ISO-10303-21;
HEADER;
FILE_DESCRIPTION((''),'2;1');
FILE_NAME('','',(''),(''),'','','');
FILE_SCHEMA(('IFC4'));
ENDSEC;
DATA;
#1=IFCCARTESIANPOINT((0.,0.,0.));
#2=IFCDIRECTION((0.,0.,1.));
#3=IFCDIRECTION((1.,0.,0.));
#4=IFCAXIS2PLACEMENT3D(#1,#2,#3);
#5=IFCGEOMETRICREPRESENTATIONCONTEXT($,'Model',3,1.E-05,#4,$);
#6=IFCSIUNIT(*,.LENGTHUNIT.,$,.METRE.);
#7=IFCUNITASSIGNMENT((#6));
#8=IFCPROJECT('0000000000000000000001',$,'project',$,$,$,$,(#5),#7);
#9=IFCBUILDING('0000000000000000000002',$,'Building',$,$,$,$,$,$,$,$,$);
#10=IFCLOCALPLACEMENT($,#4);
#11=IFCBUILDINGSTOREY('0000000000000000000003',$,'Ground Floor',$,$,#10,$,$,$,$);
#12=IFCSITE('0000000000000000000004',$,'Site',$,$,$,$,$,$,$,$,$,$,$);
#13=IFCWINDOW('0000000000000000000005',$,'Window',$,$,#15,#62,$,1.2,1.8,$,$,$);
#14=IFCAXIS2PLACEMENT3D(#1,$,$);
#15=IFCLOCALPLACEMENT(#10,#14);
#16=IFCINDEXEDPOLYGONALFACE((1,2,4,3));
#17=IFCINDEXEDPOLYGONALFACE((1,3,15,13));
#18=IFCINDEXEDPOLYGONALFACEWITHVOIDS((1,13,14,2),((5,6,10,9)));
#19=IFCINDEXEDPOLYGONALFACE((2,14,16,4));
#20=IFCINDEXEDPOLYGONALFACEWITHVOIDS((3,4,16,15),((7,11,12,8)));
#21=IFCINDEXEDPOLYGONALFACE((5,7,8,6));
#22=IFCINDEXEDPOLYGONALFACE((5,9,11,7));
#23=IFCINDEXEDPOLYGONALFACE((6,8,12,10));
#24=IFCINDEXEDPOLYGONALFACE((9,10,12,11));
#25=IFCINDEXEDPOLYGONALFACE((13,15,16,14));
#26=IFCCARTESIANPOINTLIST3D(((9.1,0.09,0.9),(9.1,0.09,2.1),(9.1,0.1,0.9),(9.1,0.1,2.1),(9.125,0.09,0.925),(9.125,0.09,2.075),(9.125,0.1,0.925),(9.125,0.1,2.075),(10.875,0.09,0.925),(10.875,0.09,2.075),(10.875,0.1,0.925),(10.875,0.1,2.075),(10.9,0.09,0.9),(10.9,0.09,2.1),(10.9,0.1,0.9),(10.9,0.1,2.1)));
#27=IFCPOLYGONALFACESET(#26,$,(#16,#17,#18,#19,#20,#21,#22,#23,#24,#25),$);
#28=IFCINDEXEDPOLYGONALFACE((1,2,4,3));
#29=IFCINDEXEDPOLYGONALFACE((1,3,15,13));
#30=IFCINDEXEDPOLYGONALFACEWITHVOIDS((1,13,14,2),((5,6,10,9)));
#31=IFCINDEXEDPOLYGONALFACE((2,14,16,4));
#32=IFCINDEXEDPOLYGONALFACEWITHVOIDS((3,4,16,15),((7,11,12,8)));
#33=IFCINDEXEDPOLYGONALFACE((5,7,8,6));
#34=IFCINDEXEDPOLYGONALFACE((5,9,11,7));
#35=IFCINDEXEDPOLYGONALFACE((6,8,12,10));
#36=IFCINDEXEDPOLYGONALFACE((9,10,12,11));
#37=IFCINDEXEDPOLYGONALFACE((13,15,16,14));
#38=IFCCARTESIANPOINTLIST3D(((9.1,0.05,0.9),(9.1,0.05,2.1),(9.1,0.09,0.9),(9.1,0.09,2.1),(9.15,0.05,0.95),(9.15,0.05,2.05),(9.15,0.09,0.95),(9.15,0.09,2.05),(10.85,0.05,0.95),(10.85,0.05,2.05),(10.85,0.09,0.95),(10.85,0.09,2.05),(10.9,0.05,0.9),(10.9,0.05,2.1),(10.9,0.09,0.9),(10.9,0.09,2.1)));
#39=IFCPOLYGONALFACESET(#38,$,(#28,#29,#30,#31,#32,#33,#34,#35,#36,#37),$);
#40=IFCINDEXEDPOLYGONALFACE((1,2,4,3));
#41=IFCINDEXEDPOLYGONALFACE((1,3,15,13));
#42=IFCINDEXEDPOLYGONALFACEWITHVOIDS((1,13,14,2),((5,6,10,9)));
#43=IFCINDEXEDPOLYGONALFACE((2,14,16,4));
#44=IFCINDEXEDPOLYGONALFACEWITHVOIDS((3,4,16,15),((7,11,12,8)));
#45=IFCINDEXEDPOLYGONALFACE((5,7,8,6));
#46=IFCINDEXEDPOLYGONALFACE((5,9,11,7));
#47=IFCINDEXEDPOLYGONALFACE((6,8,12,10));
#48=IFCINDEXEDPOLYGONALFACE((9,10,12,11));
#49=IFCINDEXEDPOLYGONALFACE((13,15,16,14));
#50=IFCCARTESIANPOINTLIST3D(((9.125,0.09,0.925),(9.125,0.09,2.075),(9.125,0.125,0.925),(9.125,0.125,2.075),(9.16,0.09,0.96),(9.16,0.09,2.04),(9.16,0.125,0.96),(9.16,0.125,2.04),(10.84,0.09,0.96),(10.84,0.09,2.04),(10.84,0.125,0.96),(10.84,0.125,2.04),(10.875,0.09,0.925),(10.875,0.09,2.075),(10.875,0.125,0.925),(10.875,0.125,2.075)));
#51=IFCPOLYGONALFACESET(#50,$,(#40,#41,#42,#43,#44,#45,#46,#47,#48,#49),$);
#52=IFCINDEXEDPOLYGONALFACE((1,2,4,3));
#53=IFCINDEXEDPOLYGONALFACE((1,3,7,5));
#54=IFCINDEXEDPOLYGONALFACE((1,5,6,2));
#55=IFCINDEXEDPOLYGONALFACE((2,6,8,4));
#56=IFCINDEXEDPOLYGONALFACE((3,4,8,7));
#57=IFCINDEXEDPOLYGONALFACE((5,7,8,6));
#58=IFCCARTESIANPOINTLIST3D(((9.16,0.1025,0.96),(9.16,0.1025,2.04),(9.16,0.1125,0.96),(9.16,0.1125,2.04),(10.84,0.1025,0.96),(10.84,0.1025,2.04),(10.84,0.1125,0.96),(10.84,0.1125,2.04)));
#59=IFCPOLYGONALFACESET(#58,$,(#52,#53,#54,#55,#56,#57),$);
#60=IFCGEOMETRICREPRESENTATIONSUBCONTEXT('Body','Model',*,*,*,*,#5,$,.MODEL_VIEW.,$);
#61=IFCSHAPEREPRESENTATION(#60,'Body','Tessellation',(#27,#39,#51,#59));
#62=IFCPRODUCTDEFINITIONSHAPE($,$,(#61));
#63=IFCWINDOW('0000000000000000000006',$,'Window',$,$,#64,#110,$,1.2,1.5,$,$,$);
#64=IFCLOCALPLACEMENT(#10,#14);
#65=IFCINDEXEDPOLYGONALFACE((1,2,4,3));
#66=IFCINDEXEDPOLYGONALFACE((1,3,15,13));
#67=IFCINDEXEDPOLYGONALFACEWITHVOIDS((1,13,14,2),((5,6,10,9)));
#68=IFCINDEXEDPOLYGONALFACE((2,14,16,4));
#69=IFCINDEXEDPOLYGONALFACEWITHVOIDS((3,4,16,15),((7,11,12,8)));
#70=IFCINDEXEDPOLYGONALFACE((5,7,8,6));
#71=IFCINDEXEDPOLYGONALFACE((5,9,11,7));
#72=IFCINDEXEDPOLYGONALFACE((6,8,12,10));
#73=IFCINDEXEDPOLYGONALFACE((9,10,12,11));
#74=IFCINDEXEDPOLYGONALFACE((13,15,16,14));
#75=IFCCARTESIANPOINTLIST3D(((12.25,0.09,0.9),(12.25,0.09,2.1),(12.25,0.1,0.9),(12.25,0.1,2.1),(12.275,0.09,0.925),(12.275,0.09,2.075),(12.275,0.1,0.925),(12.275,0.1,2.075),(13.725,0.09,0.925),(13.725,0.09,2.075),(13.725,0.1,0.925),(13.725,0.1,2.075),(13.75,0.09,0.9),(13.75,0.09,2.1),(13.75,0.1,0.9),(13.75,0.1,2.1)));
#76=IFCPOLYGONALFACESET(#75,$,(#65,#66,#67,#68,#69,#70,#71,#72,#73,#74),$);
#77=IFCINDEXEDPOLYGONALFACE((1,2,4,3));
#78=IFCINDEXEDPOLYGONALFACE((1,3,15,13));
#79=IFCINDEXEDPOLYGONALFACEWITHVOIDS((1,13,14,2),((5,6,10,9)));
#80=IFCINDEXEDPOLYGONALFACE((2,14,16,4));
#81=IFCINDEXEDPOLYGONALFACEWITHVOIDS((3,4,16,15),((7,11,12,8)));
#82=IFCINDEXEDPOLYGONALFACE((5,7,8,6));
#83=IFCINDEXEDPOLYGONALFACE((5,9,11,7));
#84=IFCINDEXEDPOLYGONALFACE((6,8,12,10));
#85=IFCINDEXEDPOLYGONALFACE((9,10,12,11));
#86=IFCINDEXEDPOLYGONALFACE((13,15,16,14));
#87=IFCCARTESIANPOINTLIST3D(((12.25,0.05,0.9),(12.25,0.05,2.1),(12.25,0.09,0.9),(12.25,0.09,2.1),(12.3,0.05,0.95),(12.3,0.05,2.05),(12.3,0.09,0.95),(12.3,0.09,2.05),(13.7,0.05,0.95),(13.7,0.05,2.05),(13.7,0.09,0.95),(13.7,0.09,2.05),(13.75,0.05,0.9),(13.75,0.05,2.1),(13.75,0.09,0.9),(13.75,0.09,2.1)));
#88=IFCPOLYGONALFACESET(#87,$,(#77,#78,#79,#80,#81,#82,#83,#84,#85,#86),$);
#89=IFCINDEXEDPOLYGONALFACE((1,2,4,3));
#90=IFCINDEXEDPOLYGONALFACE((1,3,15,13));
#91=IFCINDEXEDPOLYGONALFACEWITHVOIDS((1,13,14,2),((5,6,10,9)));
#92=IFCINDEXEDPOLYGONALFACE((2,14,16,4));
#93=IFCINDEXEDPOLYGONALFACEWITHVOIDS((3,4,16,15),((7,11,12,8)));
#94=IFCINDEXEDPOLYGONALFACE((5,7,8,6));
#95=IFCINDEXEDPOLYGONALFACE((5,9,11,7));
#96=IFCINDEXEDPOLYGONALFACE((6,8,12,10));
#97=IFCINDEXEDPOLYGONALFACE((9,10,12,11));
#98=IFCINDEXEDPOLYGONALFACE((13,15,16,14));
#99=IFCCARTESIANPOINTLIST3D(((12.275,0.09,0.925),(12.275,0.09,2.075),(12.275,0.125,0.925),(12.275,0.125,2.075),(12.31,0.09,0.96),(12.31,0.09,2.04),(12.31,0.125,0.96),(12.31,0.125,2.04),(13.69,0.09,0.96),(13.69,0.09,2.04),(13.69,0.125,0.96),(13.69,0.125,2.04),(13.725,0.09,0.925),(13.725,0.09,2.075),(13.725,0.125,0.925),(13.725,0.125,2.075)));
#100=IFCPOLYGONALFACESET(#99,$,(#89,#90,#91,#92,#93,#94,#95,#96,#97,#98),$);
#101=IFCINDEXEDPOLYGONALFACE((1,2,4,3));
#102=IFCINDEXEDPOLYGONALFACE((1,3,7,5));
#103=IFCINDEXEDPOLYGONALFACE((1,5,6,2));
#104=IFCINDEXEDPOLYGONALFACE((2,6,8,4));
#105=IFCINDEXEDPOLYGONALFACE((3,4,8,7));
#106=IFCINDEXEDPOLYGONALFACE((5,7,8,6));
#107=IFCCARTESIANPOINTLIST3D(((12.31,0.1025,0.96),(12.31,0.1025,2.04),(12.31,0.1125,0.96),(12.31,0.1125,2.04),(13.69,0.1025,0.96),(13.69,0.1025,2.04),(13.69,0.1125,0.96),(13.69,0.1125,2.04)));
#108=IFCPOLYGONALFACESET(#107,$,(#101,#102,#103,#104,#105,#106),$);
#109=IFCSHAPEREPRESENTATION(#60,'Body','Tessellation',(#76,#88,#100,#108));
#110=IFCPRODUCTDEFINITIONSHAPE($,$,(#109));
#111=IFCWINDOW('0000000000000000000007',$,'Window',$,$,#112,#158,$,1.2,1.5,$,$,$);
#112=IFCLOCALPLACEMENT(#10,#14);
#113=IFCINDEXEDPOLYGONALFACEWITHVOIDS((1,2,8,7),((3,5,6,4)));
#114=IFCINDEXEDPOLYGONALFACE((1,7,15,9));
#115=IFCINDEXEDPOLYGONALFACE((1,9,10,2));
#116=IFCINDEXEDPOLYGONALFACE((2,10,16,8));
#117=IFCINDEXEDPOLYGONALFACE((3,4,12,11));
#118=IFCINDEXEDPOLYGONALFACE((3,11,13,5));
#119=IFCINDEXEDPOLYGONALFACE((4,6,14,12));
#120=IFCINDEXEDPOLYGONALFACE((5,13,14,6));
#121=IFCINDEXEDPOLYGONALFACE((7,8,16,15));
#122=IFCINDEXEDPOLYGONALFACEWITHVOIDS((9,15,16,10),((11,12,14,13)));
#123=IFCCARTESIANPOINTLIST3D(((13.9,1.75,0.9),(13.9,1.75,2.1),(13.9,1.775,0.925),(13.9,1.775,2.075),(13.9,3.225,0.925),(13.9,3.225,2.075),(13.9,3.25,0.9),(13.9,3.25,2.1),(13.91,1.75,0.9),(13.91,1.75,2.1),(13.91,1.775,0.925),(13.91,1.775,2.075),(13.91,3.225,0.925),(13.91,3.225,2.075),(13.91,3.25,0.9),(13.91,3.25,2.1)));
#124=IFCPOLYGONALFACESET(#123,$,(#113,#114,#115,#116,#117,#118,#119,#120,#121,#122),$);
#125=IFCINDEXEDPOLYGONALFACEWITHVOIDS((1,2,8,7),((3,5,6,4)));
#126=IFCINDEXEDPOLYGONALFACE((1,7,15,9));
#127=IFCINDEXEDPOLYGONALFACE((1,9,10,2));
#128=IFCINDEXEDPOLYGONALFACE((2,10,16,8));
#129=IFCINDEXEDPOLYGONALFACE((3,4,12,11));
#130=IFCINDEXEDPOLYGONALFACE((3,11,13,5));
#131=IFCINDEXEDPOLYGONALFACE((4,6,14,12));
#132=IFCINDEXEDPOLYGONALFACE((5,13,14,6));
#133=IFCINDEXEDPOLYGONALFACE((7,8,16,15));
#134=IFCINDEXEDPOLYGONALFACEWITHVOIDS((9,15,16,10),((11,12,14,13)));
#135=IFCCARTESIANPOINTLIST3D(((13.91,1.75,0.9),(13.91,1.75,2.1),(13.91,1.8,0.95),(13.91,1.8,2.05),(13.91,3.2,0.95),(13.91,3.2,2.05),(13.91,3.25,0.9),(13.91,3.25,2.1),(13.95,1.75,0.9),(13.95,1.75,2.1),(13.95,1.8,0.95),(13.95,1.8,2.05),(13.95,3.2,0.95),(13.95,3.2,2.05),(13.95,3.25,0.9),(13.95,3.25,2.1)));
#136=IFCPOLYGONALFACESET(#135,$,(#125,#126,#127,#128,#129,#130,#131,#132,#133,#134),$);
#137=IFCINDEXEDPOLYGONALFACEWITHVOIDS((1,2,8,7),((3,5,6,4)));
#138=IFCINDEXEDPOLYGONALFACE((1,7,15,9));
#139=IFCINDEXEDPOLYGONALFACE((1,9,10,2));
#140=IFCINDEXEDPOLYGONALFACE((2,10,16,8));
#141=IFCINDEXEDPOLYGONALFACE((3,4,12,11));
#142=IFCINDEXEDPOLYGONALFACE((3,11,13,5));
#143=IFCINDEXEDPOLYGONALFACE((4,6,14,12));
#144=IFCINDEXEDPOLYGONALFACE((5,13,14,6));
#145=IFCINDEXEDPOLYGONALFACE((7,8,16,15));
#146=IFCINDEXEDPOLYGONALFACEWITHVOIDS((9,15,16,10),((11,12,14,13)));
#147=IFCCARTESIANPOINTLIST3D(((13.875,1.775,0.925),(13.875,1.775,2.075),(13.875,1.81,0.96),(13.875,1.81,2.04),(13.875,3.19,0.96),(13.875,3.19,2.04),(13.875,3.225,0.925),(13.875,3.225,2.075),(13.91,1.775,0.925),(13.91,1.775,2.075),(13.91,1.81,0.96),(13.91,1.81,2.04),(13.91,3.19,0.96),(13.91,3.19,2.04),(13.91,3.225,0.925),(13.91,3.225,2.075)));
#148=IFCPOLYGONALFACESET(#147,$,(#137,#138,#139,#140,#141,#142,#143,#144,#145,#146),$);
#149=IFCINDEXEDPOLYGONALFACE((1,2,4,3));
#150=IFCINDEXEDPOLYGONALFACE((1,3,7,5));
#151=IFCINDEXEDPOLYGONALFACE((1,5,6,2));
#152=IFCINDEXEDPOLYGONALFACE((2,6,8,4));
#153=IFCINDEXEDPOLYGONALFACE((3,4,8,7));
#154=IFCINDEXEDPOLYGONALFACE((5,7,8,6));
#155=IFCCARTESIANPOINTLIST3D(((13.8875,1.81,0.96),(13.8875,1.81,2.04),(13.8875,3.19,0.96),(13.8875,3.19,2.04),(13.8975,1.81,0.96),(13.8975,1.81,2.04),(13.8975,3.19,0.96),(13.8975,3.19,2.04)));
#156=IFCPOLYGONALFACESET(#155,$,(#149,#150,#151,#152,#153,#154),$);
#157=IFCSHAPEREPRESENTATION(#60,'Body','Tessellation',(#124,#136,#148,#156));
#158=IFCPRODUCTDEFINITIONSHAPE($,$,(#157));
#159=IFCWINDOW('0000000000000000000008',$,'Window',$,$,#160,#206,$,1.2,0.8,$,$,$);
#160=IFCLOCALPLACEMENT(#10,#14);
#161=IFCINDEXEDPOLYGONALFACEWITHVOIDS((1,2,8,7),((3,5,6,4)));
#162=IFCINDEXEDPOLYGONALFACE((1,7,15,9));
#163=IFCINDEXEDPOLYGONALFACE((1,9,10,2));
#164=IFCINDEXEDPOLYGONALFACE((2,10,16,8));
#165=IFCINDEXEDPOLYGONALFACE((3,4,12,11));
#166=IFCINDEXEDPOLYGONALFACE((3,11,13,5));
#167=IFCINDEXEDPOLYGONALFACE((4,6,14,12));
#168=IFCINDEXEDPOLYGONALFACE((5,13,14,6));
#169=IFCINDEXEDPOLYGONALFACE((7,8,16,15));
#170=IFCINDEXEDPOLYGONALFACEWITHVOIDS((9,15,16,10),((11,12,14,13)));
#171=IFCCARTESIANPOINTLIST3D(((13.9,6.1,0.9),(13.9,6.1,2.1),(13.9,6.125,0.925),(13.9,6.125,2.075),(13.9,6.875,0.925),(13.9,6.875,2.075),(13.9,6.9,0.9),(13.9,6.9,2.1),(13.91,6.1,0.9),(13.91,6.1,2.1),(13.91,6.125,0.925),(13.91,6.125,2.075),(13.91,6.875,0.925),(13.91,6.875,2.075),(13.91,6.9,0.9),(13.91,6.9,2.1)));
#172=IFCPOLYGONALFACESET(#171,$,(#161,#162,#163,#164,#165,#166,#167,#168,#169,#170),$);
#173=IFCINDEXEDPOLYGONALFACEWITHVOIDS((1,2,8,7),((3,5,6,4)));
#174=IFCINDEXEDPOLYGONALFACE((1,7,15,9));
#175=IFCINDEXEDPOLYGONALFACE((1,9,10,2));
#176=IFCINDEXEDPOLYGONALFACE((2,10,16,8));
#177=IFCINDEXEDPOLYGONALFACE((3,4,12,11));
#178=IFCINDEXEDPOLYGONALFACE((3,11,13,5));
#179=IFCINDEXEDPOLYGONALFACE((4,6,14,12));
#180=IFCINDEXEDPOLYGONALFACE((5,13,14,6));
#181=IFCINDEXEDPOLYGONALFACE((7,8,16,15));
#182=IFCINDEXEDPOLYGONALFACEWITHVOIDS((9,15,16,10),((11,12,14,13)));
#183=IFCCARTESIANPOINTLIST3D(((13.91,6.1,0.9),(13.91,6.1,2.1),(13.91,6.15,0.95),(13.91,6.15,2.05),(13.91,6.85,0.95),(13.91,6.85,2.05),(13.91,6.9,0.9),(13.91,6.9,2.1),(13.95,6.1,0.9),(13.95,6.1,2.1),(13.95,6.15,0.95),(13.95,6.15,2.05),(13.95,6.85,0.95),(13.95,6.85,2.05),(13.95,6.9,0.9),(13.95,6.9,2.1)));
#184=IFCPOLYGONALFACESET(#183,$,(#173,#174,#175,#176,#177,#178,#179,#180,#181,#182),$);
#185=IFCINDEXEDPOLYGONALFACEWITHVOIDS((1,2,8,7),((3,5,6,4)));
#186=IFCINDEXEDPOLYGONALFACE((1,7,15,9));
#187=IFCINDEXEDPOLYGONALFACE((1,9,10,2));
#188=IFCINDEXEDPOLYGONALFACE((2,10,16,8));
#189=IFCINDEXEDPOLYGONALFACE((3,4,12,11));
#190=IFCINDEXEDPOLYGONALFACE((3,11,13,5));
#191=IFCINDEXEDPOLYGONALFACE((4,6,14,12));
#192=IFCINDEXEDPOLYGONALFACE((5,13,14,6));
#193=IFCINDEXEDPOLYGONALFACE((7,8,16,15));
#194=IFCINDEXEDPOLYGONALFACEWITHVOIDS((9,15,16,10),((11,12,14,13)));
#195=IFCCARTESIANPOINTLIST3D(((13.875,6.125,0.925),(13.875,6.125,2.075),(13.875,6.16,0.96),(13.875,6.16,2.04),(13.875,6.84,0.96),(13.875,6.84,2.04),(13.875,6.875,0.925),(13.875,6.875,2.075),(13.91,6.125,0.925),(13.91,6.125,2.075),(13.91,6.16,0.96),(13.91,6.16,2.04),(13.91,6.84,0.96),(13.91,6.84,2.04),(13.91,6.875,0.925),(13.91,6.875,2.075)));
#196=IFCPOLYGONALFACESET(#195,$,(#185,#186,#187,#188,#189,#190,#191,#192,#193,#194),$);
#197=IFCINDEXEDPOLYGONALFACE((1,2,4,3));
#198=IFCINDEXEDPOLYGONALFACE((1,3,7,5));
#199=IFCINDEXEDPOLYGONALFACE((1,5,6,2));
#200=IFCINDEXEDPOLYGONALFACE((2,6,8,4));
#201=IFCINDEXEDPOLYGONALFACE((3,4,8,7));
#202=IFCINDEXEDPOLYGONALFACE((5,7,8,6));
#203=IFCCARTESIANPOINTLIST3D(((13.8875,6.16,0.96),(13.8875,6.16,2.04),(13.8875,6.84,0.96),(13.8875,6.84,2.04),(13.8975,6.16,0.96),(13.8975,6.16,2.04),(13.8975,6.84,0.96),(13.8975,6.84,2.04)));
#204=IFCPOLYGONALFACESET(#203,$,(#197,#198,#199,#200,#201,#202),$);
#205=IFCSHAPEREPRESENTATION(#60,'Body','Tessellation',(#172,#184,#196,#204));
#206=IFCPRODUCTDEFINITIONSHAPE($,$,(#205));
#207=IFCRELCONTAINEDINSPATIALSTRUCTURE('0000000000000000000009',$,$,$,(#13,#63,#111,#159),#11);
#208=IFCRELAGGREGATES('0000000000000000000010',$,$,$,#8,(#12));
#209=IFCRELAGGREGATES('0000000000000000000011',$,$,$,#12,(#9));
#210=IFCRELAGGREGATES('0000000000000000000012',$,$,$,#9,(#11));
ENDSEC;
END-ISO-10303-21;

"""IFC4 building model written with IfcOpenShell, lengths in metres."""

from ifc_helpers import new_model, si_unit, frame, origin_with_axes, place, context, subcontext, project, spatial, line, indexed_curve, outline, extrude, element, save


model = new_model("IFC4")

# Units and contexts
model_context = context("Model", 3, precision=1e-05, world=origin_with_axes())
body_context = subcontext(model_context, "Body", "Model", "MODEL_VIEW")
ifc_project = project(units=[si_unit("LENGTHUNIT", "METRE")], contexts=[model_context])

# Site, building, storey
site = spatial("IfcSite", under=ifc_project, Name="Site")
building = spatial("IfcBuilding", under=site, Name="Building")
storey_placement = place(None, origin_with_axes())
storey = spatial("IfcBuildingStorey", under=building, at=storey_placement, Name="Ground Floor")

# Windows
window_1_placement = place(storey_placement, frame((9.1, 0.0, 0.9), z_axis=(0.0, 0.0, 1.0), x_axis=(1.0, 0.0, 0.0)))
element("IfcWindow", 1, at=window_1_placement, inside=storey, Name="Window", OverallHeight=1.2, OverallWidth=1.8, context=body_context, shape_type="SweptSolid", body=[
    extrude(outline(indexed_curve([(0.0, 0.0), (1.8, 0.0), (1.8, 1.2), (0.0, 1.2)], segments=[line(1, 2, 3, 4, 1)]), holes=[indexed_curve([(0.025, 0.025), (1.775, 0.025), (1.775, 1.175), (0.025, 1.175)], segments=[line(1, 2, 3, 4, 1)])]), frame((0.0, 0.09, 0.0), z_axis=(0.0, -1.0, 0.0), x_axis=(1.0, 0.0, 0.0)), (0.0, 0.0, -1.0), 0.01),
    extrude(outline(indexed_curve([(0.0, 0.0), (1.8, 0.0), (1.8, 1.2), (0.0, 1.2)], segments=[line(1, 2, 3, 4, 1)]), holes=[indexed_curve([(0.05, 0.05), (1.75, 0.05), (1.75, 1.15), (0.05, 1.15)], segments=[line(1, 2, 3, 4, 1)])]), frame((0.0, 0.05, 0.0), z_axis=(0.0, -1.0, 0.0), x_axis=(1.0, 0.0, 0.0)), (0.0, 0.0, -1.0), 0.04),
    extrude(outline(indexed_curve([(0.0, 0.0), (1.75, 0.0), (1.75, 1.15), (0.0, 1.15)], segments=[line(1, 2, 3, 4, 1)]), holes=[indexed_curve([(0.035, 0.035), (1.715, 0.035), (1.715, 1.115), (0.035, 1.115)], segments=[line(1, 2, 3, 4, 1)])]), frame((0.025, 0.09, 0.025), z_axis=(0.0, -1.0, 0.0), x_axis=(1.0, 0.0, 0.0)), (0.0, 0.0, -1.0), 0.035),
    extrude(outline(indexed_curve([(0.035, 0.035), (1.715, 0.035), (1.715, 1.115), (0.035, 1.115)], segments=[line(1, 2, 3, 4, 1)])), frame((0.025, 0.1025, 0.025), z_axis=(0.0, -1.0, 0.0), x_axis=(1.0, 0.0, 0.0)), (0.0, 0.0, -1.0), 0.01),
])
for number, where, z_axis, x_axis, name in (
    (2, (12.25, 0.0, 0.9), (0.0, 0.0, 1.0), (1.0, 0.0, 0.0), "Window"),
    (3, (14.0, 1.75, 0.9), (0.0, 0.0, 1.0), (0.0, 1.0, 0.0), "Window"),
):
    element("IfcWindow", number, at=place(storey_placement, frame(where, z_axis=z_axis, x_axis=x_axis)), inside=storey, Name=name, OverallHeight=1.2, OverallWidth=1.5, context=body_context, shape_type="SweptSolid", body=[
        extrude(outline(indexed_curve([(0.0, 0.0), (1.5, 0.0), (1.5, 1.2), (0.0, 1.2)], segments=[line(1, 2, 3, 4, 1)]), holes=[indexed_curve([(0.025, 0.025), (1.475, 0.025), (1.475, 1.175), (0.025, 1.175)], segments=[line(1, 2, 3, 4, 1)])]), frame((0.0, 0.09, 0.0), z_axis=(0.0, -1.0, 0.0), x_axis=(1.0, 0.0, 0.0)), (0.0, 0.0, -1.0), 0.01),
        extrude(outline(indexed_curve([(0.0, 0.0), (1.5, 0.0), (1.5, 1.2), (0.0, 1.2)], segments=[line(1, 2, 3, 4, 1)]), holes=[indexed_curve([(0.05, 0.05), (1.45, 0.05), (1.45, 1.15), (0.05, 1.15)], segments=[line(1, 2, 3, 4, 1)])]), frame((0.0, 0.05, 0.0), z_axis=(0.0, -1.0, 0.0), x_axis=(1.0, 0.0, 0.0)), (0.0, 0.0, -1.0), 0.04),
        extrude(outline(indexed_curve([(0.0, 0.0), (1.45, 0.0), (1.45, 1.15), (0.0, 1.15)], segments=[line(1, 2, 3, 4, 1)]), holes=[indexed_curve([(0.035, 0.035), (1.415, 0.035), (1.415, 1.115), (0.035, 1.115)], segments=[line(1, 2, 3, 4, 1)])]), frame((0.025, 0.09, 0.025), z_axis=(0.0, -1.0, 0.0), x_axis=(1.0, 0.0, 0.0)), (0.0, 0.0, -1.0), 0.035),
        extrude(outline(indexed_curve([(0.035, 0.035), (1.415, 0.035), (1.415, 1.115), (0.035, 1.115)], segments=[line(1, 2, 3, 4, 1)])), frame((0.025, 0.1025, 0.025), z_axis=(0.0, -1.0, 0.0), x_axis=(1.0, 0.0, 0.0)), (0.0, 0.0, -1.0), 0.01),
    ])
window_2_placement = place(storey_placement, frame((14.0, 6.1, 0.9), z_axis=(0.0, 0.0, 1.0), x_axis=(0.0, 1.0, 0.0)))
element("IfcWindow", 4, at=window_2_placement, inside=storey, Name="Window", OverallHeight=1.2, OverallWidth=0.8, context=body_context, shape_type="SweptSolid", body=[
    extrude(outline(indexed_curve([(0.0, 0.0), (0.8, 0.0), (0.8, 1.2), (0.0, 1.2)], segments=[line(1, 2, 3, 4, 1)]), holes=[indexed_curve([(0.025, 0.025), (0.775, 0.025), (0.775, 1.175), (0.025, 1.175)], segments=[line(1, 2, 3, 4, 1)])]), frame((0.0, 0.09, 0.0), z_axis=(0.0, -1.0, 0.0), x_axis=(1.0, 0.0, 0.0)), (0.0, 0.0, -1.0), 0.01),
    extrude(outline(indexed_curve([(0.0, 0.0), (0.8, 0.0), (0.8, 1.2), (0.0, 1.2)], segments=[line(1, 2, 3, 4, 1)]), holes=[indexed_curve([(0.05, 0.05), (0.75, 0.05), (0.75, 1.15), (0.05, 1.15)], segments=[line(1, 2, 3, 4, 1)])]), frame((0.0, 0.05, 0.0), z_axis=(0.0, -1.0, 0.0), x_axis=(1.0, 0.0, 0.0)), (0.0, 0.0, -1.0), 0.04),
    extrude(outline(indexed_curve([(0.0, 0.0), (0.75, 0.0), (0.75, 1.15), (0.0, 1.15)], segments=[line(1, 2, 3, 4, 1)]), holes=[indexed_curve([(0.035, 0.035), (0.715, 0.035), (0.715, 1.115), (0.035, 1.115)], segments=[line(1, 2, 3, 4, 1)])]), frame((0.025, 0.09, 0.025), z_axis=(0.0, -1.0, 0.0), x_axis=(1.0, 0.0, 0.0)), (0.0, 0.0, -1.0), 0.035),
    extrude(outline(indexed_curve([(0.035, 0.035), (0.715, 0.035), (0.715, 1.115), (0.035, 1.115)], segments=[line(1, 2, 3, 4, 1)])), frame((0.025, 0.1025, 0.025), z_axis=(0.0, -1.0, 0.0), x_axis=(1.0, 0.0, 0.0)), (0.0, 0.0, -1.0), 0.01),
])

save(model, "model.ifc")
